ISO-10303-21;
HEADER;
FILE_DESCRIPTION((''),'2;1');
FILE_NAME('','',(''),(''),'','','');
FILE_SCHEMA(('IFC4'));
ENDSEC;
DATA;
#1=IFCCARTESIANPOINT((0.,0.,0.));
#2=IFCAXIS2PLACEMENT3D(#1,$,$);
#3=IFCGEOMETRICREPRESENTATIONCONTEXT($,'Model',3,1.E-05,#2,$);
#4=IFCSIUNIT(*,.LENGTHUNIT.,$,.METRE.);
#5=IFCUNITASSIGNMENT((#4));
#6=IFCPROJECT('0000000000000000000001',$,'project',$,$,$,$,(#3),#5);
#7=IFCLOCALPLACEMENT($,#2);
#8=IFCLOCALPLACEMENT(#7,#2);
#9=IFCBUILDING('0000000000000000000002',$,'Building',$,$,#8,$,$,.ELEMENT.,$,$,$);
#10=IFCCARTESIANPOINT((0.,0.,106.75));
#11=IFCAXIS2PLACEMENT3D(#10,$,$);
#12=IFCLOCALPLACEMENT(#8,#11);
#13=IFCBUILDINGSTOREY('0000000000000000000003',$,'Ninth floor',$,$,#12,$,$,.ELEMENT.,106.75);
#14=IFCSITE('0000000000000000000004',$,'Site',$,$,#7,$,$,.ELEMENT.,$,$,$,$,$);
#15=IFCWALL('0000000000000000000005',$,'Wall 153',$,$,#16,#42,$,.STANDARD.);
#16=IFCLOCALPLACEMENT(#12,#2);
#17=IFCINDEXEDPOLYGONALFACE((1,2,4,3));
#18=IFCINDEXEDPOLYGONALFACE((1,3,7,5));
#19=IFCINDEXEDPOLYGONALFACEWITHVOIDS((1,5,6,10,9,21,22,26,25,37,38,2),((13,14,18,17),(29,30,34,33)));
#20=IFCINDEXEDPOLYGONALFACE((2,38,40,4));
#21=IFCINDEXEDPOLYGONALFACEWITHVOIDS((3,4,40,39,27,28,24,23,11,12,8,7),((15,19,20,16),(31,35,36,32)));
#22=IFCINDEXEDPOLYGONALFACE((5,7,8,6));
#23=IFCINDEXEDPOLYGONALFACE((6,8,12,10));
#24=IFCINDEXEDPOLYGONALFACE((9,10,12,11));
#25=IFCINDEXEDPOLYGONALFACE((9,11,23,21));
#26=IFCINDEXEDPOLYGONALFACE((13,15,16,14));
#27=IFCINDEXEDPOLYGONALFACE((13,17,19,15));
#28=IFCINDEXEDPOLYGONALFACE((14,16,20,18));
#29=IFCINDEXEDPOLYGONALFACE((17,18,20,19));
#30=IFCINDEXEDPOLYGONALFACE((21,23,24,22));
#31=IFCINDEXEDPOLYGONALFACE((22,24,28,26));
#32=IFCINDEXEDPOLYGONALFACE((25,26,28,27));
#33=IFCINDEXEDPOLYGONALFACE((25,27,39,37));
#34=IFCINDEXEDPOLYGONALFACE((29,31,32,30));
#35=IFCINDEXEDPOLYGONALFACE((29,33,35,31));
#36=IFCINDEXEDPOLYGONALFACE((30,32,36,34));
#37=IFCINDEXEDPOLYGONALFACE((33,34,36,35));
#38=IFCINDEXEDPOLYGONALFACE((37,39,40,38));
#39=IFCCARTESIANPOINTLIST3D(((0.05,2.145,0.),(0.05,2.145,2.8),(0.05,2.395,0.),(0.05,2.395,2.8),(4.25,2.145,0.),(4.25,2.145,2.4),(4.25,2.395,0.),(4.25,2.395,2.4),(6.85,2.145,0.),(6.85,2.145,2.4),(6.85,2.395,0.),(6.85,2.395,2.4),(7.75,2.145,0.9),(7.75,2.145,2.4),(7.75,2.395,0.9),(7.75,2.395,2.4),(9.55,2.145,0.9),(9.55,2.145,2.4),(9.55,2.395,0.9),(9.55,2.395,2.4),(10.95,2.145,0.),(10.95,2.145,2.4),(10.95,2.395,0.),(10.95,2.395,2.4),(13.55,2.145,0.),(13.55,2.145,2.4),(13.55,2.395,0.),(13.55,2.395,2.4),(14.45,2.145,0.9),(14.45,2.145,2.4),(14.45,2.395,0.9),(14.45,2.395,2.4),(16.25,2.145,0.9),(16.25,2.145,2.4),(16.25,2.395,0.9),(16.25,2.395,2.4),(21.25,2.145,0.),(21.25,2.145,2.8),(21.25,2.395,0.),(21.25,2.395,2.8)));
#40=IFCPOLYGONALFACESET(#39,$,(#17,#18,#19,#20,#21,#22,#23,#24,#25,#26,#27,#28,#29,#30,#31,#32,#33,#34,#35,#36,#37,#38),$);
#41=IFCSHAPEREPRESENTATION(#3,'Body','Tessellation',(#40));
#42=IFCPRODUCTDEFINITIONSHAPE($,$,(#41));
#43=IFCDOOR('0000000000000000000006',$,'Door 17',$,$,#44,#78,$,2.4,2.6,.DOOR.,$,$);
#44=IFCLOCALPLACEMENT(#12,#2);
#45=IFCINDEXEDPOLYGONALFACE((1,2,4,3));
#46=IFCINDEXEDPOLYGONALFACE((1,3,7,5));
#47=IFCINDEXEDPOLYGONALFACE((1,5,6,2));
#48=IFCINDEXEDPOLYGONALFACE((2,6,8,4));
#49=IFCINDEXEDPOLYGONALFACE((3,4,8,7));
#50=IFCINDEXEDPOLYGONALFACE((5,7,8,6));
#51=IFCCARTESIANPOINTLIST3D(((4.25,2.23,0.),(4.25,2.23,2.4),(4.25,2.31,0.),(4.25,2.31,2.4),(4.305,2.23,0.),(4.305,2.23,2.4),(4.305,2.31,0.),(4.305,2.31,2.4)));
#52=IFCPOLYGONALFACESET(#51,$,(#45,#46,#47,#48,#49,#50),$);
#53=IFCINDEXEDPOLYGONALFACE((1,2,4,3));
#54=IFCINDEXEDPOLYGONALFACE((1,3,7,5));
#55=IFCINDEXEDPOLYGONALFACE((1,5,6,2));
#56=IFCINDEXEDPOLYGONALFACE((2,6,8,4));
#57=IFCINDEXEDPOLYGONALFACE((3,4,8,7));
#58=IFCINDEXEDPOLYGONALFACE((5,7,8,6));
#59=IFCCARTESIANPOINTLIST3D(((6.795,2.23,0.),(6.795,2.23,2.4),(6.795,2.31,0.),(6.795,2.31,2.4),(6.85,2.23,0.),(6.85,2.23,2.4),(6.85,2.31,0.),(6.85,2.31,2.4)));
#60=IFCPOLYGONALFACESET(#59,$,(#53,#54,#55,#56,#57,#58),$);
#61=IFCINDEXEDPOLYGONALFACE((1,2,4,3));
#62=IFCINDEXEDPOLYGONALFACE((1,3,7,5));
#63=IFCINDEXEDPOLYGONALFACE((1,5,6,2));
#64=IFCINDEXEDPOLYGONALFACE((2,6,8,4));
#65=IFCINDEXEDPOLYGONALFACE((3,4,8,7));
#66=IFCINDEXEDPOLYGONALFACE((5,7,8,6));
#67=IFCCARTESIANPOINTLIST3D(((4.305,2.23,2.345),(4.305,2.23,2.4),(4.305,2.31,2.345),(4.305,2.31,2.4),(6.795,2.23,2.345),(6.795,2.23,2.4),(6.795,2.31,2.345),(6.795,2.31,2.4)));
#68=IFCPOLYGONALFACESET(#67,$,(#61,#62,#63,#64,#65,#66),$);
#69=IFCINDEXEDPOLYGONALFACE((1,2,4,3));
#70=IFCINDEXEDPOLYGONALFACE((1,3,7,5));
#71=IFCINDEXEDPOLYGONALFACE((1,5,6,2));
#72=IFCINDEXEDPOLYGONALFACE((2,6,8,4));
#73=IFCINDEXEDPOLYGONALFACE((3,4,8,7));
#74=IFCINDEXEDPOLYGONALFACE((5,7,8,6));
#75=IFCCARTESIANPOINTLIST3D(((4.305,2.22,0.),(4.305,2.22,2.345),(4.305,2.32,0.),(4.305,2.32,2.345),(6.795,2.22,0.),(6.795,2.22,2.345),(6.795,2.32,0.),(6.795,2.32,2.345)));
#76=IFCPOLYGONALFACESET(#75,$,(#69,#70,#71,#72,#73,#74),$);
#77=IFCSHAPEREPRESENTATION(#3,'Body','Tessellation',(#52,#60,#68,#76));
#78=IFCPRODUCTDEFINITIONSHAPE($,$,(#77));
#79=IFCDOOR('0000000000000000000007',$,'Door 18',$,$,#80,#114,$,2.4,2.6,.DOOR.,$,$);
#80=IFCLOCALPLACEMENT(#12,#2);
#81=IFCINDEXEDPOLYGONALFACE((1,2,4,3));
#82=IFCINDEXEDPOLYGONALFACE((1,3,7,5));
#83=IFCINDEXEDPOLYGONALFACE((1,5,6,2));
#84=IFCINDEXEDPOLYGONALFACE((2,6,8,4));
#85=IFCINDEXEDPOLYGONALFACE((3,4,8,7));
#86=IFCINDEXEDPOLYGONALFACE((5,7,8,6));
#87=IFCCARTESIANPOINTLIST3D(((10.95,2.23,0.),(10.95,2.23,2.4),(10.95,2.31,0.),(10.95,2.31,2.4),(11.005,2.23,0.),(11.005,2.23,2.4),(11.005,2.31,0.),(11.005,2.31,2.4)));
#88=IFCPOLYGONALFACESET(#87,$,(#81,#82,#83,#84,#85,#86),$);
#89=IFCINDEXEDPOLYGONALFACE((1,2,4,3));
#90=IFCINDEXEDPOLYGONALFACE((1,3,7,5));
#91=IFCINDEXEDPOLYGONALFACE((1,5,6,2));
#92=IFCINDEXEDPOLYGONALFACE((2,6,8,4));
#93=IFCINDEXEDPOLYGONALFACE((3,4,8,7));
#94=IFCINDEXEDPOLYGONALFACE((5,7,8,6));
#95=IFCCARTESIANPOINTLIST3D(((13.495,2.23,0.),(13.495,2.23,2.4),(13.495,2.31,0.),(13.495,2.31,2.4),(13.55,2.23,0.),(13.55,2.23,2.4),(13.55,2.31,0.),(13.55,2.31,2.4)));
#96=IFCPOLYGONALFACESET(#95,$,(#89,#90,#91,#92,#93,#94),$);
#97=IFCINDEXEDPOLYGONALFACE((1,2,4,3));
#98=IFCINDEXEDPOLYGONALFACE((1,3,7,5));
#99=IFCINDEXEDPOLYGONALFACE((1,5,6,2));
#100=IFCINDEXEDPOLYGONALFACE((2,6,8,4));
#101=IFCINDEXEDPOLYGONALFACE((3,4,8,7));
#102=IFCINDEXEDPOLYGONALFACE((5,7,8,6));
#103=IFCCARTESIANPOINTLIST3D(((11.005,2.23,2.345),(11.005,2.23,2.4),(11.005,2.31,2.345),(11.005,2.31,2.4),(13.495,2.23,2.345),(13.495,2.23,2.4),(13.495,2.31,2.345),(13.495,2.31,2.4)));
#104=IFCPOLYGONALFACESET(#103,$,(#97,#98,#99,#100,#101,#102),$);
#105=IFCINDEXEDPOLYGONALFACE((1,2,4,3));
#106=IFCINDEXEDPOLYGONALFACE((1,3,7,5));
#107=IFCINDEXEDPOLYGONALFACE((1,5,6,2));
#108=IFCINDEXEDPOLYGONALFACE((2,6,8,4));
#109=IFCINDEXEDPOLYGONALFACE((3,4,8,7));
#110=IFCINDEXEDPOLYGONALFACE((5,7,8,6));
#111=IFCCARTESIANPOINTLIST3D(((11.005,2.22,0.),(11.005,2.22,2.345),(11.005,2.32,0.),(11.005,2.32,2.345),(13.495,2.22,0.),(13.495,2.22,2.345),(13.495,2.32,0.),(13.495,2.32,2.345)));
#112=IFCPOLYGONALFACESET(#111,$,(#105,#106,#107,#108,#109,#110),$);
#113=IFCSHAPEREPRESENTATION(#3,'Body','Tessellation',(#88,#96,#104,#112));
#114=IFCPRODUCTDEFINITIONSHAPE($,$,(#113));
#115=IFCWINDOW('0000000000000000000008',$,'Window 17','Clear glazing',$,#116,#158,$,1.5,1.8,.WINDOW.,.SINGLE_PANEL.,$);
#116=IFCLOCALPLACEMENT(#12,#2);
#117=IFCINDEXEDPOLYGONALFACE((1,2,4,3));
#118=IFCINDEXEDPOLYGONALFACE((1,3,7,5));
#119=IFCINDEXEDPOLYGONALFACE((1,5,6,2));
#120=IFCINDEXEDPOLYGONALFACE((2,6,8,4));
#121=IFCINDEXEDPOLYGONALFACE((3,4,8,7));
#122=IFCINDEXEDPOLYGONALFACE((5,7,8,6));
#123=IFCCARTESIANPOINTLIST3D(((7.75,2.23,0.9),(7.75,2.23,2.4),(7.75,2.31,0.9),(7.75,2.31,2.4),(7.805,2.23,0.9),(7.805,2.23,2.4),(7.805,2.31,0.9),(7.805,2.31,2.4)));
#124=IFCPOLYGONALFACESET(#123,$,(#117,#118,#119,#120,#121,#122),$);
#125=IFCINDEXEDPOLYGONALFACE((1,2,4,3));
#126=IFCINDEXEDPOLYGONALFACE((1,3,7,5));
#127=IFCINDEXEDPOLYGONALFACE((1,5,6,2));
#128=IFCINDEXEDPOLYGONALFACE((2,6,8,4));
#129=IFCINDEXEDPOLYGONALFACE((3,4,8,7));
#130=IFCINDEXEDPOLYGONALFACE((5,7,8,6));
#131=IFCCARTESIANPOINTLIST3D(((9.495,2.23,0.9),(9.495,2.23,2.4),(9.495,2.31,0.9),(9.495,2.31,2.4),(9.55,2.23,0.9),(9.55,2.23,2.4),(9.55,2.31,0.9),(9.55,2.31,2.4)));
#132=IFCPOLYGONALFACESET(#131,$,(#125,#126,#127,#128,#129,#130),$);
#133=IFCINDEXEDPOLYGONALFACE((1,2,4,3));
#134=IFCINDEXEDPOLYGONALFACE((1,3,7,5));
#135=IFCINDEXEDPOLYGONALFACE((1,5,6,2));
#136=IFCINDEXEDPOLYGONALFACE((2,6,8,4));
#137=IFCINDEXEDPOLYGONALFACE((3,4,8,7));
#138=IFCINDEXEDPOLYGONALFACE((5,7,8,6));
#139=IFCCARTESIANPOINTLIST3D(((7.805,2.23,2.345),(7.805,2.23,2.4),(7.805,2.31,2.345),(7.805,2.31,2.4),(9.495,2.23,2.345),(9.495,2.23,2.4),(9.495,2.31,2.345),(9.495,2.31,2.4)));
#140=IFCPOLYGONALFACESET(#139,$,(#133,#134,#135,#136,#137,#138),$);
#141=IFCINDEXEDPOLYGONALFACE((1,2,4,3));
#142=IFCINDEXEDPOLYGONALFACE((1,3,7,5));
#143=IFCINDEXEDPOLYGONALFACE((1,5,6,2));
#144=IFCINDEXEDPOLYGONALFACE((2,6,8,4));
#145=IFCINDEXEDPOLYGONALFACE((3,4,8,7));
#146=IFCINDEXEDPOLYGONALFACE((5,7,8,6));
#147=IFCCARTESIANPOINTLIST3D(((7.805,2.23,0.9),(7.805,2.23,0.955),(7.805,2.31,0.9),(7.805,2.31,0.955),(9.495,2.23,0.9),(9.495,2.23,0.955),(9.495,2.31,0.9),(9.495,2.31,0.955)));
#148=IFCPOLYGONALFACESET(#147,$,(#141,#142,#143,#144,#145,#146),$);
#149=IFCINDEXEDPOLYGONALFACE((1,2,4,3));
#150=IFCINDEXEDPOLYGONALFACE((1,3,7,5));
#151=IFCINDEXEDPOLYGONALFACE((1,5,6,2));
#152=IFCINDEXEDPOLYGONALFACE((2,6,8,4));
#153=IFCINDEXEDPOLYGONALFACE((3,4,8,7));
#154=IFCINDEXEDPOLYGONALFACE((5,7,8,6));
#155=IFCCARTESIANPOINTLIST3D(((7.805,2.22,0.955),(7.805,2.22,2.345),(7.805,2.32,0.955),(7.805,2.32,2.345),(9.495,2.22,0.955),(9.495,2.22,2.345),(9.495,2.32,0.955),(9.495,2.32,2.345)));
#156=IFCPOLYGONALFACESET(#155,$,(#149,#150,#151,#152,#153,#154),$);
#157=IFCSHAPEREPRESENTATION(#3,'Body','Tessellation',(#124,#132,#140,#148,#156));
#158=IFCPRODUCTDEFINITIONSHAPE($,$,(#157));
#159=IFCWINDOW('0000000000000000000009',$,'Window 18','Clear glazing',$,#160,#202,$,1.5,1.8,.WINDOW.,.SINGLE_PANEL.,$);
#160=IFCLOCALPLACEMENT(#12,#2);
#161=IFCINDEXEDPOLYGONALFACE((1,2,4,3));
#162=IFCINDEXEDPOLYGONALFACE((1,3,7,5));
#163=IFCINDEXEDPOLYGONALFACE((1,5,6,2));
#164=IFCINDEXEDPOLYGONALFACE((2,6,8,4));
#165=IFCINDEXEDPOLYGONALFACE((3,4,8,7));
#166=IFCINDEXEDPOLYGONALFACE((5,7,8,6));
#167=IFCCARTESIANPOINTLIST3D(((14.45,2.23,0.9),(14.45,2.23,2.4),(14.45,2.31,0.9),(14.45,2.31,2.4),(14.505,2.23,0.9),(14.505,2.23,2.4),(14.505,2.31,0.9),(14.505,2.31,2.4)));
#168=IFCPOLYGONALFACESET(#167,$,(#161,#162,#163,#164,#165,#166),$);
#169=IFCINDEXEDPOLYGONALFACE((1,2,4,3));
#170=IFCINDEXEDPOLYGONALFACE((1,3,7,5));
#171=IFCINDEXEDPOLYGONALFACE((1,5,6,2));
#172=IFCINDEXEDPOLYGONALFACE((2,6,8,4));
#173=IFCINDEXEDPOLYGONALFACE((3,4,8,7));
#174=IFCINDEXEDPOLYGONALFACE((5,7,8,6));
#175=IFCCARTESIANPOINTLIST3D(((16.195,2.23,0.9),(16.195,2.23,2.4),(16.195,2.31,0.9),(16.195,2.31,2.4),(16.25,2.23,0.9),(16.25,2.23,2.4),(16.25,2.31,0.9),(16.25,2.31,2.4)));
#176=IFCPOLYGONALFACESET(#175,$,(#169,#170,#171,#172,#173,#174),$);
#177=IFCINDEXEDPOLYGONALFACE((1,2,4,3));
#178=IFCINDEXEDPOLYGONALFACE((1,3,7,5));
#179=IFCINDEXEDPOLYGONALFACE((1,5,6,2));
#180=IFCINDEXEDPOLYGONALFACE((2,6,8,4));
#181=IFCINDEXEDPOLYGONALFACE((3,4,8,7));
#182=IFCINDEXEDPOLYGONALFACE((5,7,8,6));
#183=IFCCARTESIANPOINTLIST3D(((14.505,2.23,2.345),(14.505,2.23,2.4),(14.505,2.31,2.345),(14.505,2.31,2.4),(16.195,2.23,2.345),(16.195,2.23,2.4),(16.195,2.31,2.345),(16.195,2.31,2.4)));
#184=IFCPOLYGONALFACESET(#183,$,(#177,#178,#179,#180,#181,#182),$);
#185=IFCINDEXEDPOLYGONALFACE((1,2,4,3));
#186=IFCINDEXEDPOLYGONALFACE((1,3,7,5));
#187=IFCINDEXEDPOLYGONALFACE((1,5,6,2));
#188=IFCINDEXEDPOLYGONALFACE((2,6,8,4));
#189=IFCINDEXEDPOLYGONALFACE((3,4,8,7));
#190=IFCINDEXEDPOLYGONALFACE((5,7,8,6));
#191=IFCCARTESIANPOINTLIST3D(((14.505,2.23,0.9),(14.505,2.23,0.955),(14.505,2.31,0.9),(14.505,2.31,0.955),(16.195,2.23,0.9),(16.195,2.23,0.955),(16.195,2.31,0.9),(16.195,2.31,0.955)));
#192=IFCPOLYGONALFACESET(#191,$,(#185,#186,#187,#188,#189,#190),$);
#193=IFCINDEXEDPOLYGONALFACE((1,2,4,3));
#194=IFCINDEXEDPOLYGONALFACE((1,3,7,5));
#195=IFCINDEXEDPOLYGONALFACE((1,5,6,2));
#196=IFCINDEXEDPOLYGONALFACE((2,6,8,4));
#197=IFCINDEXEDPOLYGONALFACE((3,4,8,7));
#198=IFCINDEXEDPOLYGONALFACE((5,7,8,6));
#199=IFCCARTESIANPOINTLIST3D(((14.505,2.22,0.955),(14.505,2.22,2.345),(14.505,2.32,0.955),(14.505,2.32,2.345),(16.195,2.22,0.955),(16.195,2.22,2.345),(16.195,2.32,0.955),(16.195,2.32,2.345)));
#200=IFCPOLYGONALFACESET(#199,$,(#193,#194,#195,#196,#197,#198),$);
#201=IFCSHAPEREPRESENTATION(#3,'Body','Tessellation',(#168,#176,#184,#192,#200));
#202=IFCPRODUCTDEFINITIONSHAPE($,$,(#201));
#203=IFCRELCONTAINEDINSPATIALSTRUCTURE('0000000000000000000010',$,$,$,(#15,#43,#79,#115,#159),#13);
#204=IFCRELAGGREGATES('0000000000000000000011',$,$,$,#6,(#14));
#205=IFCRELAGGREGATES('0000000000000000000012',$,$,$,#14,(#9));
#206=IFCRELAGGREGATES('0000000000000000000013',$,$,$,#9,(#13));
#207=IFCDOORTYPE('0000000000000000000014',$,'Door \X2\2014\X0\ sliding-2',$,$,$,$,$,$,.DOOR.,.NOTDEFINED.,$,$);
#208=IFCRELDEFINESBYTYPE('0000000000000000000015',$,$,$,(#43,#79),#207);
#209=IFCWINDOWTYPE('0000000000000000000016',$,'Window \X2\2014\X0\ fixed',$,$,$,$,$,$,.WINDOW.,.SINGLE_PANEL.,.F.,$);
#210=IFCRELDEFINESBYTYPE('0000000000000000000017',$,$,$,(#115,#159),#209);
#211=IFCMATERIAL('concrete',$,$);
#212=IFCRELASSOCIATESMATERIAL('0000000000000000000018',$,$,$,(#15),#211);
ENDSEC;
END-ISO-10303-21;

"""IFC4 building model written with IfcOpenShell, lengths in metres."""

from ifc_helpers import new_model, si_unit, frame, frame_2d, origin, place, context, project, spatial, rectangle, extrude, material, type_object, element, fill, save


model = new_model("IFC4")

# Units and contexts
model_context = context("Model", 3, precision=1e-05, world=origin())
ifc_project = project(units=[si_unit("LENGTHUNIT", "METRE")], contexts=[model_context])

# Site, building, storey
site_placement = place(None, origin())
site = spatial("IfcSite", under=ifc_project, at=site_placement, Name="Site", CompositionType="ELEMENT")
building_placement = place(site_placement, origin())
building = spatial("IfcBuilding", under=site, at=building_placement, Name="Building", CompositionType="ELEMENT")
storey_placement = place(building_placement, frame((0.0, 0.0, 106.75)))
storey = spatial("IfcBuildingStorey", under=building, at=storey_placement, Name="Ninth floor", CompositionType="ELEMENT", Elevation=106.75)

# Shared definitions
ifc_material = material(Name="concrete")

# Wall, openings, doors, windows
wall_1_placement = place(storey_placement, frame((0.05, 2.27, 0.0), z_axis=(0.0, 0.0, 1.0), x_axis=(1.0, 0.0, 0.0)))
wall_1 = element("IfcWall", 1, at=wall_1_placement, inside=storey, material=ifc_material, Name="Wall 153", PredefinedType="STANDARD", context=model_context, shape_type="SweptSolid", body=[
    extrude(rectangle(XDim=21.2, YDim=0.25, at=frame_2d((10.6, 0.0))), origin(), (0.0, 0.0, 1.0), 2.8),
])
opening_1_placement = place(storey_placement, frame((4.25, 2.27, 0.0), z_axis=(0.0, 0.0, 1.0), x_axis=(1.0, 0.0, 0.0)))
opening_1 = element("IfcOpeningElement", 2, at=opening_1_placement, cuts=wall_1, PredefinedType="OPENING", context=model_context, shape_type="SweptSolid", body=[
    extrude(rectangle(XDim=2.6, YDim=0.31, at=frame_2d((1.3, 0.0))), origin(), (0.0, 0.0, 1.0), 2.4),
])
opening_2_placement = place(storey_placement, frame((7.75, 2.27, 0.9), z_axis=(0.0, 0.0, 1.0), x_axis=(1.0, 0.0, 0.0)))
opening_2 = element("IfcOpeningElement", 3, at=opening_2_placement, cuts=wall_1, PredefinedType="OPENING", context=model_context, shape_type="SweptSolid", body=[
    extrude(rectangle(XDim=1.8, YDim=0.31, at=frame_2d((0.9, 0.0))), origin(), (0.0, 0.0, 1.0), 1.5),
])
opening_3_placement = place(storey_placement, frame((10.95, 2.27, 0.0), z_axis=(0.0, 0.0, 1.0), x_axis=(1.0, 0.0, 0.0)))
opening_3 = element("IfcOpeningElement", 4, at=opening_3_placement, cuts=wall_1, PredefinedType="OPENING", context=model_context, shape_type="SweptSolid", body=[
    extrude(rectangle(XDim=2.6, YDim=0.31, at=frame_2d((1.3, 0.0))), origin(), (0.0, 0.0, 1.0), 2.4),
])
opening_4_placement = place(storey_placement, frame((14.45, 2.27, 0.9), z_axis=(0.0, 0.0, 1.0), x_axis=(1.0, 0.0, 0.0)))
opening_4 = element("IfcOpeningElement", 5, at=opening_4_placement, cuts=wall_1, PredefinedType="OPENING", context=model_context, shape_type="SweptSolid", body=[
    extrude(rectangle(XDim=1.8, YDim=0.31, at=frame_2d((0.9, 0.0))), origin(), (0.0, 0.0, 1.0), 1.5),
])
door_type = type_object("IfcDoorType", Name="Door — sliding-2", PredefinedType="DOOR")
door_1_placement = place(storey_placement, frame((4.25, 2.27, 0.0), z_axis=(0.0, 0.0, 1.0), x_axis=(1.0, 0.0, 0.0)))
door_1 = element("IfcDoor", 6, at=door_1_placement, inside=storey, type_object=door_type, Name="Door 17", OverallHeight=2.4, OverallWidth=2.6, PredefinedType="DOOR", context=model_context, shape_type="SweptSolid", body=[
    extrude(rectangle(XDim=0.055, YDim=0.08, at=frame_2d((0.0275, 0.0))), origin(), (0.0, 0.0, 1.0), 2.4),
    extrude(rectangle(XDim=0.055, YDim=0.08, at=frame_2d((2.5725, 0.0))), origin(), (0.0, 0.0, 1.0), 2.4),
    extrude(rectangle(XDim=2.49, YDim=0.08, at=frame_2d((1.3, 0.0))), frame((0.0, 0.0, 2.345)), (0.0, 0.0, 1.0), 0.055),
    extrude(rectangle(XDim=2.49, YDim=0.1, at=frame_2d((1.3, 0.0))), origin(), (0.0, 0.0, 1.0), 2.345),
])
fill(opening_1, door_1)
door_2_placement = place(storey_placement, frame((10.95, 2.27, 0.0), z_axis=(0.0, 0.0, 1.0), x_axis=(1.0, 0.0, 0.0)))
door_2 = element("IfcDoor", 7, at=door_2_placement, inside=storey, type_object=door_type, Name="Door 18", OverallHeight=2.4, OverallWidth=2.6, PredefinedType="DOOR", context=model_context, shape_type="SweptSolid", body=[
    extrude(rectangle(XDim=0.055, YDim=0.08, at=frame_2d((0.0275, 0.0))), origin(), (0.0, 0.0, 1.0), 2.4),
    extrude(rectangle(XDim=0.055, YDim=0.08, at=frame_2d((2.5725, 0.0))), origin(), (0.0, 0.0, 1.0), 2.4),
    extrude(rectangle(XDim=2.49, YDim=0.08, at=frame_2d((1.3, 0.0))), frame((0.0, 0.0, 2.345)), (0.0, 0.0, 1.0), 0.055),
    extrude(rectangle(XDim=2.49, YDim=0.1, at=frame_2d((1.3, 0.0))), origin(), (0.0, 0.0, 1.0), 2.345),
])
fill(opening_3, door_2)
window_type = type_object("IfcWindowType", Name="Window — fixed", ParameterTakesPrecedence=False, PartitioningType="SINGLE_PANEL", PredefinedType="WINDOW")
window_1_placement = place(storey_placement, frame((7.75, 2.27, 0.9), z_axis=(0.0, 0.0, 1.0), x_axis=(1.0, 0.0, 0.0)))
window_1 = element("IfcWindow", 8, at=window_1_placement, inside=storey, type_object=window_type, Name="Window 17", Description="Clear glazing", OverallHeight=1.5, OverallWidth=1.8, PartitioningType="SINGLE_PANEL", PredefinedType="WINDOW", context=model_context, shape_type="SweptSolid", body=[
    extrude(rectangle(XDim=0.055, YDim=0.08, at=frame_2d((0.0275, 0.0))), origin(), (0.0, 0.0, 1.0), 1.5),
    extrude(rectangle(XDim=0.055, YDim=0.08, at=frame_2d((1.7725, 0.0))), origin(), (0.0, 0.0, 1.0), 1.5),
    extrude(rectangle(XDim=1.69, YDim=0.08, at=frame_2d((0.9, 0.0))), frame((0.0, 0.0, 1.445)), (0.0, 0.0, 1.0), 0.055),
    extrude(rectangle(XDim=1.69, YDim=0.08, at=frame_2d((0.9, 0.0))), origin(), (0.0, 0.0, 1.0), 0.055),
    extrude(rectangle(XDim=1.69, YDim=0.1, at=frame_2d((0.9, 0.0))), frame((0.0, 0.0, 0.055)), (0.0, 0.0, 1.0), 1.39),
])
fill(opening_2, window_1)
window_2_placement = place(storey_placement, frame((14.45, 2.27, 0.9), z_axis=(0.0, 0.0, 1.0), x_axis=(1.0, 0.0, 0.0)))
window_2 = element("IfcWindow", 9, at=window_2_placement, inside=storey, type_object=window_type, Name="Window 18", Description="Clear glazing", OverallHeight=1.5, OverallWidth=1.8, PartitioningType="SINGLE_PANEL", PredefinedType="WINDOW", context=model_context, shape_type="SweptSolid", body=[
    extrude(rectangle(XDim=0.055, YDim=0.08, at=frame_2d((0.0275, 0.0))), origin(), (0.0, 0.0, 1.0), 1.5),
    extrude(rectangle(XDim=0.055, YDim=0.08, at=frame_2d((1.7725, 0.0))), origin(), (0.0, 0.0, 1.0), 1.5),
    extrude(rectangle(XDim=1.69, YDim=0.08, at=frame_2d((0.9, 0.0))), frame((0.0, 0.0, 1.445)), (0.0, 0.0, 1.0), 0.055),
    extrude(rectangle(XDim=1.69, YDim=0.08, at=frame_2d((0.9, 0.0))), origin(), (0.0, 0.0, 1.0), 0.055),
    extrude(rectangle(XDim=1.69, YDim=0.1, at=frame_2d((0.9, 0.0))), frame((0.0, 0.0, 0.055)), (0.0, 0.0, 1.0), 1.39),
])
fill(opening_4, window_2)

save(model, "model.ifc")
